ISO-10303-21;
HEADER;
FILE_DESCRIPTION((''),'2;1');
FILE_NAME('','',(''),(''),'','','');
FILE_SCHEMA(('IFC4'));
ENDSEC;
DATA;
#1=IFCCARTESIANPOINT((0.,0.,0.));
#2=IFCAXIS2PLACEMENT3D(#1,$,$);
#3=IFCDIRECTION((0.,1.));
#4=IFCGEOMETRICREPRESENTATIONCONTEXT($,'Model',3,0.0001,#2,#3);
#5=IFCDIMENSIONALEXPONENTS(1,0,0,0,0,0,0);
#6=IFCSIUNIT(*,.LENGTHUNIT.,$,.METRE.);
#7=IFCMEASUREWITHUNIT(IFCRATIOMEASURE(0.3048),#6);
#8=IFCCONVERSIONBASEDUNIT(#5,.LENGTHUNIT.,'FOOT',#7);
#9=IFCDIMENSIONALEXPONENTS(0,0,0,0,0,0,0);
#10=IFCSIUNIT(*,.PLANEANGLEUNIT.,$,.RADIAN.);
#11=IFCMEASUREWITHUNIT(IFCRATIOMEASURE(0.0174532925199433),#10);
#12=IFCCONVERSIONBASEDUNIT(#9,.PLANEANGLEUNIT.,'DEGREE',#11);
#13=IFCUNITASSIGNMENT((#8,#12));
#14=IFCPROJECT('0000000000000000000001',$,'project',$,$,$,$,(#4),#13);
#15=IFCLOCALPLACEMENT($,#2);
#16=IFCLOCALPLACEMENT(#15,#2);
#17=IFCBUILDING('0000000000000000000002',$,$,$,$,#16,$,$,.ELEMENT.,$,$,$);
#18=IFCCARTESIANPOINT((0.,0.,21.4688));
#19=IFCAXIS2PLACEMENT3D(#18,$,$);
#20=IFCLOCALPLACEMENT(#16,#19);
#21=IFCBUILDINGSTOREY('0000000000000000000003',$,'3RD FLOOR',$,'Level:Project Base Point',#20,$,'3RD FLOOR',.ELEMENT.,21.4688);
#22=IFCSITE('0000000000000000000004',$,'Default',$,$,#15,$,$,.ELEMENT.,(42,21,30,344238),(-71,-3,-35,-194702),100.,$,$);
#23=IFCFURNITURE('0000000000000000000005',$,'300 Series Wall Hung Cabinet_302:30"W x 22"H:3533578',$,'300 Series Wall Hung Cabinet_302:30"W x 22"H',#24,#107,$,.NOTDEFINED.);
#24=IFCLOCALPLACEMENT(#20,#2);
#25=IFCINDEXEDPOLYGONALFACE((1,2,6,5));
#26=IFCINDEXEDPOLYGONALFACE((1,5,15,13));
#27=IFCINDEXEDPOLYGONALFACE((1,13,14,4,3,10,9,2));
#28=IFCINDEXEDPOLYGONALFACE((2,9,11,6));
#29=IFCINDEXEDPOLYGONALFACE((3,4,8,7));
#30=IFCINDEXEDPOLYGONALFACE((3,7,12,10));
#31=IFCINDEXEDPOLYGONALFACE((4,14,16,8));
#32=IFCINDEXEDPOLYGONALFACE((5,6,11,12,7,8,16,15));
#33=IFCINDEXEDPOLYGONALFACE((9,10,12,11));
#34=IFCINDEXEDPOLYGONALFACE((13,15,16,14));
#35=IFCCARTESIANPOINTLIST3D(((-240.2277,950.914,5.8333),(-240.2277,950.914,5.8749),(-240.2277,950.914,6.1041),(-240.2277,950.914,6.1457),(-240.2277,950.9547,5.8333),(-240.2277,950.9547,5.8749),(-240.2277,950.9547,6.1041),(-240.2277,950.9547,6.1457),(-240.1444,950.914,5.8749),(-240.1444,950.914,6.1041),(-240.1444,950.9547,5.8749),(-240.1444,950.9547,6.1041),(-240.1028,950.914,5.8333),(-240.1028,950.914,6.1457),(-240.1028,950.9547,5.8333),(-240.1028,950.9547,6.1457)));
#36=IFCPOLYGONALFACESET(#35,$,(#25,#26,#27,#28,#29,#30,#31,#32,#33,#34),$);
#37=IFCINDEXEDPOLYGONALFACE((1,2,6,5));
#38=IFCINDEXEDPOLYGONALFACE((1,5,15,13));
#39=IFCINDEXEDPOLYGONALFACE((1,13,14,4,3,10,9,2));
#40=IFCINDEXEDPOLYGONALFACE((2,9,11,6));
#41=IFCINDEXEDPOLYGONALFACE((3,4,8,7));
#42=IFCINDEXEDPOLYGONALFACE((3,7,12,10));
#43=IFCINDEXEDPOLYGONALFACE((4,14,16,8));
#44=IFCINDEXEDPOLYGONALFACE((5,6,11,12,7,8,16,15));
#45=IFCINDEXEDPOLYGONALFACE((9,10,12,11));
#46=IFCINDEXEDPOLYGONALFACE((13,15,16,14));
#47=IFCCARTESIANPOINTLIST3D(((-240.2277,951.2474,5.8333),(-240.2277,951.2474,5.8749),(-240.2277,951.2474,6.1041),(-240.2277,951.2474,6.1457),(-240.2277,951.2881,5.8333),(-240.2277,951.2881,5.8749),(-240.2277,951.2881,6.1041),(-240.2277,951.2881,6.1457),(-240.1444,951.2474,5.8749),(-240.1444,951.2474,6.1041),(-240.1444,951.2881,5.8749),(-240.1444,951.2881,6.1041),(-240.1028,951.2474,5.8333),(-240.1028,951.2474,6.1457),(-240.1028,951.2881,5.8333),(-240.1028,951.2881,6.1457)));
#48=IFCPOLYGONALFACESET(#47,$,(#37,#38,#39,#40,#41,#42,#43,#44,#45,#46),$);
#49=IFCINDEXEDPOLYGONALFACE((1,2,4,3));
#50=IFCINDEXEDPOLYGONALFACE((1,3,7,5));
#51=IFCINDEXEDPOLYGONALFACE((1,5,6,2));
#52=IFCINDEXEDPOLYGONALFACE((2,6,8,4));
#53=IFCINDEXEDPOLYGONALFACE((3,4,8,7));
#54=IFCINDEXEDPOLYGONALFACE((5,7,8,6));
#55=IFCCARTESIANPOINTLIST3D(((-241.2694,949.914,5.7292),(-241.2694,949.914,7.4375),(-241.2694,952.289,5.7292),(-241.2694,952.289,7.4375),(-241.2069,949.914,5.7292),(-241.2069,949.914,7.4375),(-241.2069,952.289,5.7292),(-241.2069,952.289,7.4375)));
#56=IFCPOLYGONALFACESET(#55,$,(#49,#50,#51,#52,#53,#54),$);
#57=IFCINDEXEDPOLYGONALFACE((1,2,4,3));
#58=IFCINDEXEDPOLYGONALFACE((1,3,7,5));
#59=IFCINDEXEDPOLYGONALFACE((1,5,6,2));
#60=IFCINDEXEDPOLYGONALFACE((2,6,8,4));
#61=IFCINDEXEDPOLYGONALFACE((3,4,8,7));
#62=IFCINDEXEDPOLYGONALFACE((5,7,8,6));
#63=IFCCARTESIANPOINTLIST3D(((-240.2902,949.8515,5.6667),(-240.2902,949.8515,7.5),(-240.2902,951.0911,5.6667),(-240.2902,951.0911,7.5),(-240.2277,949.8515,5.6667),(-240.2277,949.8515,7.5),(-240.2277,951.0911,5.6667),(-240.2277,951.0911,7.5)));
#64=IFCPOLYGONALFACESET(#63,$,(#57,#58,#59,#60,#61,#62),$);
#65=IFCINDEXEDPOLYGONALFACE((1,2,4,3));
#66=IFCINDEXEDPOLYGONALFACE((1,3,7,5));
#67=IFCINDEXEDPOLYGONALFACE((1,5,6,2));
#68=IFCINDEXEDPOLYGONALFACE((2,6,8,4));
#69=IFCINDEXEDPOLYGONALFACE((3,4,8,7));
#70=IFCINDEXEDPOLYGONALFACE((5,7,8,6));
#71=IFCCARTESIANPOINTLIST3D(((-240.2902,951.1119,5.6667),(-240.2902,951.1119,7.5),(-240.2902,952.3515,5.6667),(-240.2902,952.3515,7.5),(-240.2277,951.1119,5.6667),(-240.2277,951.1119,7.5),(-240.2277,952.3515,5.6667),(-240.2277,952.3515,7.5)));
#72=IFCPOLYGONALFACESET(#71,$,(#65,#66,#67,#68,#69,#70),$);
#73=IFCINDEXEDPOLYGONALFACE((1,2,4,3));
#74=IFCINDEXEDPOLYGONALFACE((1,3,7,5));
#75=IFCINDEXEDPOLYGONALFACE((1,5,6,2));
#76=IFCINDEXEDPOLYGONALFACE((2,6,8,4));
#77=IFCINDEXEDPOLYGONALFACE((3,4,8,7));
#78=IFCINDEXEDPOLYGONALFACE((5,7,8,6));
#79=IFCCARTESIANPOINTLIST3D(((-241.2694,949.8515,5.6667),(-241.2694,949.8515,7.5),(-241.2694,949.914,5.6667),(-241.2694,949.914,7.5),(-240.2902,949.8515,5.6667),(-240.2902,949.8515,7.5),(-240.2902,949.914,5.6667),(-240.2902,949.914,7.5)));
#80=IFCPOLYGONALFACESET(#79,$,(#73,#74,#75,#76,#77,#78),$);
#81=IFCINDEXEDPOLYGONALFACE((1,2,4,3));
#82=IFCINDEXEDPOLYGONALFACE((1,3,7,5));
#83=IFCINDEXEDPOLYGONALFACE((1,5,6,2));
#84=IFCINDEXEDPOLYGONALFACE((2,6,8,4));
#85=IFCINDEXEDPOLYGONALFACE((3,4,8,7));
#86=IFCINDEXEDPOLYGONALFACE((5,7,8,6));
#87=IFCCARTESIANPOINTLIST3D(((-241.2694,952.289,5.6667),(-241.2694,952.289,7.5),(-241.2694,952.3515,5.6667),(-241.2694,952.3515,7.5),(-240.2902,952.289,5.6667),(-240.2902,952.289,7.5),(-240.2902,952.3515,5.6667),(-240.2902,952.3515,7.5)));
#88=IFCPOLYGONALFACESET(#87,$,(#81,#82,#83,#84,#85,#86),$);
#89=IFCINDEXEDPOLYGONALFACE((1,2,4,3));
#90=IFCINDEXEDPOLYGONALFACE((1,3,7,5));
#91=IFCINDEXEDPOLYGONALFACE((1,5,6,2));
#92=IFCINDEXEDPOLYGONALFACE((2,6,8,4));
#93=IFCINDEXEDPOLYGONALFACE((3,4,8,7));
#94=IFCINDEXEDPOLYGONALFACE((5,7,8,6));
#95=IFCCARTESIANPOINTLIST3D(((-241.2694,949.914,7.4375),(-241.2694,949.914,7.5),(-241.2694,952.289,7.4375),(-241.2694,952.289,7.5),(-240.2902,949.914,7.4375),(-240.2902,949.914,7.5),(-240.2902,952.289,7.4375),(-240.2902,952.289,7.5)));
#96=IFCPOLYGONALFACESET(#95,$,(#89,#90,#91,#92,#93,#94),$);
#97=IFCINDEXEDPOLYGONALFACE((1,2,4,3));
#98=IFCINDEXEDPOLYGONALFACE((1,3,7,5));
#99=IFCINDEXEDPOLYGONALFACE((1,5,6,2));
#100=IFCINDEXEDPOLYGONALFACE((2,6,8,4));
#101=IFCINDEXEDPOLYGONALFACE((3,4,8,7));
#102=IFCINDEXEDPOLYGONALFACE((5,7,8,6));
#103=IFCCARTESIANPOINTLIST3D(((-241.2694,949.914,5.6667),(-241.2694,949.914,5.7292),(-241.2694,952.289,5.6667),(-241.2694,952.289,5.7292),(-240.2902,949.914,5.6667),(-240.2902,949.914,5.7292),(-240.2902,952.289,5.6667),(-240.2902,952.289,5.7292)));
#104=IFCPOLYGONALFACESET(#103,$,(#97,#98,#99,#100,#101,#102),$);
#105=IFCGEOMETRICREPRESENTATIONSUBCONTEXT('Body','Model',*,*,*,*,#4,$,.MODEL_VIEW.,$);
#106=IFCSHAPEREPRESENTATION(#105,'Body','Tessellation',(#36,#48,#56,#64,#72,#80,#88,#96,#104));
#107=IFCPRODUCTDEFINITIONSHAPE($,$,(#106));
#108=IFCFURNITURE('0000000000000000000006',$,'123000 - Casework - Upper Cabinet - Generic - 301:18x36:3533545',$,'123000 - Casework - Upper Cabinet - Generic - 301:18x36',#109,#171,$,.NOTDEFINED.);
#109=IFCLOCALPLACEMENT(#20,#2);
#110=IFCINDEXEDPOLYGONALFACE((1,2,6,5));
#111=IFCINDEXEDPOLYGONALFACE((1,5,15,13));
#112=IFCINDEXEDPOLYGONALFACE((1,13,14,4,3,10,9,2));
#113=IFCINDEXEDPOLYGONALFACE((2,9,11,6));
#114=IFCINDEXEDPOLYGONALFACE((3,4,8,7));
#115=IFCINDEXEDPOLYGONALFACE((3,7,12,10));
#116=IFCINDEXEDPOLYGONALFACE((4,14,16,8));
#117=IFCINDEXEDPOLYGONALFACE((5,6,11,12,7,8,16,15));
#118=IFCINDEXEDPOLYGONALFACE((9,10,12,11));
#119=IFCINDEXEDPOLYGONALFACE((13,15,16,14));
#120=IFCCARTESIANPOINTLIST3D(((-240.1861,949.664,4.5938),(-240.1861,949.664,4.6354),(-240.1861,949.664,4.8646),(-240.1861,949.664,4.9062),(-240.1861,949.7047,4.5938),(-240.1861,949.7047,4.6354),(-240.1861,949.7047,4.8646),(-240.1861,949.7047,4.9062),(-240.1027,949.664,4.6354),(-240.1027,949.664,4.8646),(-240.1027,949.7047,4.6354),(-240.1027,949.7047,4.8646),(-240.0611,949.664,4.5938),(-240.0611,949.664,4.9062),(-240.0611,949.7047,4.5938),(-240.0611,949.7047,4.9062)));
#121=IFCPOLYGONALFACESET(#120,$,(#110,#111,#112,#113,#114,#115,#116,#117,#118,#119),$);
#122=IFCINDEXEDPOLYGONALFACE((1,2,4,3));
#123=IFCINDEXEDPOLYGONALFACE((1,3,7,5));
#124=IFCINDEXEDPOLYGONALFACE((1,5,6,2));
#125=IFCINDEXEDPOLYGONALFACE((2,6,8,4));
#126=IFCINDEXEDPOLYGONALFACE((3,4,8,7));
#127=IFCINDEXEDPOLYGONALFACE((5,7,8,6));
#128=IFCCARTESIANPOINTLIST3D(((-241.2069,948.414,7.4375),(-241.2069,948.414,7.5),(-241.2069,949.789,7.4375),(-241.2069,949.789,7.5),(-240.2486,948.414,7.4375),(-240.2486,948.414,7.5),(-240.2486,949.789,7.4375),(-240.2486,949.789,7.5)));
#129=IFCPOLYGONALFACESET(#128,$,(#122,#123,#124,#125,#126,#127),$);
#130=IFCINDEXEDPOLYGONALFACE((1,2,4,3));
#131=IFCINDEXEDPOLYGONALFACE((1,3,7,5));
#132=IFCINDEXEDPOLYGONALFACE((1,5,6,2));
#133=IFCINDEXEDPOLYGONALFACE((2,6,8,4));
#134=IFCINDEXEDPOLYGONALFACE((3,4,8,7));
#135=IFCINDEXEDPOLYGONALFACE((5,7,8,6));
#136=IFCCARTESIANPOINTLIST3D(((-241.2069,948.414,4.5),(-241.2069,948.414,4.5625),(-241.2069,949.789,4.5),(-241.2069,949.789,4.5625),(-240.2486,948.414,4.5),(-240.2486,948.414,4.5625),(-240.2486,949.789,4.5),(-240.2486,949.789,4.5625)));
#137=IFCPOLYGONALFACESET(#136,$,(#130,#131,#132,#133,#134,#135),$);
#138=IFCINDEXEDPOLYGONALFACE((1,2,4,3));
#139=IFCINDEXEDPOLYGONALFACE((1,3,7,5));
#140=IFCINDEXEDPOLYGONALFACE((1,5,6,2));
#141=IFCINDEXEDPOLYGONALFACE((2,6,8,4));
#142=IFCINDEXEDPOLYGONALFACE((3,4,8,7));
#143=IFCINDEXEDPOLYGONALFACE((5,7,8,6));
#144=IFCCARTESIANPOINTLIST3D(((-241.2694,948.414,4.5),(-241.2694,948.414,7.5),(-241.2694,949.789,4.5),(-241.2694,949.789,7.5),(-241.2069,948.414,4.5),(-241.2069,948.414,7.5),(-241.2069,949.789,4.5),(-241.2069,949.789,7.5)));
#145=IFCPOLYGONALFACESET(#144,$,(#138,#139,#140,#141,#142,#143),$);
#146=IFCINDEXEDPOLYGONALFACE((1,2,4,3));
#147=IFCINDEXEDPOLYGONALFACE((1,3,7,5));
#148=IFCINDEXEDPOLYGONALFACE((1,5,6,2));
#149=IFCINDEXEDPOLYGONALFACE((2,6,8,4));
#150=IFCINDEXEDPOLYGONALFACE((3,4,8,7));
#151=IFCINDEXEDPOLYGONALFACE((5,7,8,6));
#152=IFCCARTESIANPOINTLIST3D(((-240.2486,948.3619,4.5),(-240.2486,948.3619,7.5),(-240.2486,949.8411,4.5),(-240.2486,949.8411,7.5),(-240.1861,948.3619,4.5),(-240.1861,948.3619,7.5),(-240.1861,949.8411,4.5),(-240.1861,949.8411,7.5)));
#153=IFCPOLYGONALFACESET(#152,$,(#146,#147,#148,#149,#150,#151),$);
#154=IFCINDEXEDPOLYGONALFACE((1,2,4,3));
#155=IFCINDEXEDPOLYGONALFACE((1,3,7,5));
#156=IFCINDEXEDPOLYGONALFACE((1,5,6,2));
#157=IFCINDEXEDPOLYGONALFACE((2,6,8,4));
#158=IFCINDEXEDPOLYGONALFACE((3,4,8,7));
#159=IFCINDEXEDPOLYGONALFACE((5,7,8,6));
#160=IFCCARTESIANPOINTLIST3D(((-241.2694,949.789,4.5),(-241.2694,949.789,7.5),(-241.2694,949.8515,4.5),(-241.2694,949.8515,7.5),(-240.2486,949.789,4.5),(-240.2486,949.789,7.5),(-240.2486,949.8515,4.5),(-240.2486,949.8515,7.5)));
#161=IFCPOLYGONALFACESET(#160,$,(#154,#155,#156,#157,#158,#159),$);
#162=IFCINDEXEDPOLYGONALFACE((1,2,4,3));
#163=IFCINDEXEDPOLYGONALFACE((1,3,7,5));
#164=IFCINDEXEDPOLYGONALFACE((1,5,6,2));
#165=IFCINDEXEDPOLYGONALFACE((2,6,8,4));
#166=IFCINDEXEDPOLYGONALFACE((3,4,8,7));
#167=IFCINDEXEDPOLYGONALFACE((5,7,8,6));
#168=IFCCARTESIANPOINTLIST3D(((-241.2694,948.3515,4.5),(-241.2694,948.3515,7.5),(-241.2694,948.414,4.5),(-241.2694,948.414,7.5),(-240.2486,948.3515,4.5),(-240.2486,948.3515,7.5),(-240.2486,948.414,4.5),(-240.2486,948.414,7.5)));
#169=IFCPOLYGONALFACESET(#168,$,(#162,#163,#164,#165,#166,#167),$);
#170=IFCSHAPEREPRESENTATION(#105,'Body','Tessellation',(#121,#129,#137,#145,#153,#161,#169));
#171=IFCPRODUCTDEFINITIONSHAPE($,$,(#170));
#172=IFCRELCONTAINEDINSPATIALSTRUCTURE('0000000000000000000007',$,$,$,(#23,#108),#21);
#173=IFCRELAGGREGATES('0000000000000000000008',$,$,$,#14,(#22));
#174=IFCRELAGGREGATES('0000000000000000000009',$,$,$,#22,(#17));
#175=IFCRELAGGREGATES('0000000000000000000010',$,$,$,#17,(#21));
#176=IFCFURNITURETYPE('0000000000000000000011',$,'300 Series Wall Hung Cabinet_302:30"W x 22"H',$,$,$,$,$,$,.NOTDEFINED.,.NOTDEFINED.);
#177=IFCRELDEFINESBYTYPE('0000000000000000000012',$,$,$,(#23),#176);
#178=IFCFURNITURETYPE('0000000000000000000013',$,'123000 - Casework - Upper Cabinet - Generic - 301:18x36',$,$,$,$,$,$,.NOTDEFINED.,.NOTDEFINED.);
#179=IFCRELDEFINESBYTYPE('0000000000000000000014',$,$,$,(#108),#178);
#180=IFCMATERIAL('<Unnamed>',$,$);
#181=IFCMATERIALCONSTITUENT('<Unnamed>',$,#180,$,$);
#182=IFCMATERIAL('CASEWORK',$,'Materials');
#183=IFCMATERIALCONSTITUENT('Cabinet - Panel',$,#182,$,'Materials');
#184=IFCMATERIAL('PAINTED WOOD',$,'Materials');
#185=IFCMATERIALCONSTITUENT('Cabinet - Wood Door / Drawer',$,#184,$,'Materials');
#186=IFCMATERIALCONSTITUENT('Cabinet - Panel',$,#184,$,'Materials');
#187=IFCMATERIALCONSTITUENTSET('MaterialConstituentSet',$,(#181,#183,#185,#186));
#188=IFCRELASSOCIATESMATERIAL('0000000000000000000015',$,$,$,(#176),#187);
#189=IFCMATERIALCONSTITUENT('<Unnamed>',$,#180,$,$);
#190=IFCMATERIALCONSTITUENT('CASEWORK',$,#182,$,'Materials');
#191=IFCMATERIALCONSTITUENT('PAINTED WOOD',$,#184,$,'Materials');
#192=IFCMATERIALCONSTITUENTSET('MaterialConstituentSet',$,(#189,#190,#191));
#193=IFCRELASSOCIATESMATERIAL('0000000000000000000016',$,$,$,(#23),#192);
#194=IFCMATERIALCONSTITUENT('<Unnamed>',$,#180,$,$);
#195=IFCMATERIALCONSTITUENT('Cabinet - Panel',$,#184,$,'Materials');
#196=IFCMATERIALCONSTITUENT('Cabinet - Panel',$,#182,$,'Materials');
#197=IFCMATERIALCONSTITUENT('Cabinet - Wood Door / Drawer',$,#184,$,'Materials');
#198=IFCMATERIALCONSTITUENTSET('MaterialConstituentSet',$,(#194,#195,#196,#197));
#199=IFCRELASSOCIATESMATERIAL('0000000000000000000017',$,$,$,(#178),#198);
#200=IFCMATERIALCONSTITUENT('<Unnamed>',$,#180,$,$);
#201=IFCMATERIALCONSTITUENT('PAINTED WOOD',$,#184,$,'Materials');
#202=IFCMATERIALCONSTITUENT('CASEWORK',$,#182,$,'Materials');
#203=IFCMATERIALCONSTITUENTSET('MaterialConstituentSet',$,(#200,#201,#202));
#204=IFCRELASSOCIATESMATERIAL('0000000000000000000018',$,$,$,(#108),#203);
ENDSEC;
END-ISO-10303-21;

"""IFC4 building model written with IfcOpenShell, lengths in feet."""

from ifc_helpers import new_model, entity, si_unit, converted_unit, direction, frame, frame_2d, origin, origin_2d_with_axis, place, context, subcontext, project, spatial, polyline, rectangle, outline, extrude, source, transform, mapped, material, constituent, constituent_set, type_object, type_shapes, element, save


model = new_model("IFC4")

# Units and contexts
model_context = context("Model", 3, precision=0.0001, world=origin(), true_north=direction((0.0, 1.0)))
body_context = subcontext(model_context, "Body", "Model", "MODEL_VIEW")
ifc_project = project(units=[converted_unit("LENGTHUNIT", "FOOT", entity("IfcRatioMeasure", 0.3048), si_unit("LENGTHUNIT", "METRE"), dimensions=[1, 0, 0, 0, 0, 0, 0]), converted_unit("PLANEANGLEUNIT", "DEGREE", entity("IfcRatioMeasure", 0.0174532925199433), si_unit("PLANEANGLEUNIT", "RADIAN"), dimensions=[0, 0, 0, 0, 0, 0, 0])], contexts=[model_context])

# Site, building, storey
site_placement = place(None, origin())
site = spatial("IfcSite", under=ifc_project, at=site_placement, Name="Default", CompositionType="ELEMENT", RefLatitude=(42, 21, 30, 344238), RefLongitude=(-71, -3, -35, -194702), RefElevation=100.0)
building_placement = place(site_placement, origin())
building = spatial("IfcBuilding", under=site, at=building_placement, CompositionType="ELEMENT")
storey_placement = place(building_placement, frame((0.0, 0.0, 21.4688)))
storey = spatial("IfcBuildingStorey", under=building, at=storey_placement, Name="3RD FLOOR", ObjectType="Level:Project Base Point", LongName="3RD FLOOR", CompositionType="ELEMENT", Elevation=21.4688)

# Furniture
ifc_material_1 = material(Name="PAINTED WOOD", Category="Materials")
ifc_material_2 = material(Name="CASEWORK", Category="Materials")
ifc_material_3 = material(Name="<Unnamed>")
ifc_constituent_1 = constituent(ifc_material_3, Name="<Unnamed>")
ifc_constituent_2 = constituent(ifc_material_2, Name="CASEWORK", Category="Materials")
ifc_constituent_3 = constituent(ifc_material_1, Name="PAINTED WOOD", Category="Materials")
ifc_constituent_set_1 = constituent_set(constituents=[ifc_constituent_1, ifc_constituent_2, ifc_constituent_3], Name="MaterialConstituentSet")
ifc_constituent_4 = constituent(ifc_material_3, Name="<Unnamed>")
ifc_constituent_5 = constituent(ifc_material_2, Name="Cabinet - Panel", Category="Materials")
ifc_constituent_6 = constituent(ifc_material_1, Name="Cabinet - Wood Door / Drawer", Category="Materials")
ifc_constituent_7 = constituent(ifc_material_1, Name="Cabinet - Panel", Category="Materials")
ifc_constituent_set_2 = constituent_set(constituents=[ifc_constituent_4, ifc_constituent_5, ifc_constituent_6, ifc_constituent_7], Name="MaterialConstituentSet")
furniture_type_1 = type_object("IfcFurnitureType", Name="300 Series Wall Hung Cabinet_302:30\"W x 22\"H", AssemblyPlace="NOTDEFINED", PredefinedType="NOTDEFINED", material=ifc_constituent_set_2)
shared_shape_1 = source(origin(), body_context, "Body", "SweptSolid", [
    extrude(outline(polyline([(0.1146, -0.0521), (0.1562, -0.0521), (0.1562, 0.0729), (-0.1562, 0.0729), (-0.1562, -0.0521), (-0.1146, -0.0521), (-0.1146, 0.0313), (0.1146, 0.0313), (0.1146, -0.0521)])), frame((1.0625, 0.0729, 0.3229), z_axis=(1.0, 0.0, 0.0), x_axis=(0.0, 0.0, 1.0)), (0.0, 0.0, 1.0), 0.0407),
    extrude(outline(polyline([(0.1146, -0.0521), (0.1562, -0.0521), (0.1562, 0.0729), (-0.1562, 0.0729), (-0.1562, -0.0521), (-0.1146, -0.0521), (-0.1146, 0.0313), (0.1146, 0.0313), (0.1146, -0.0521)])), frame((1.3958, 0.0729, 0.3229), z_axis=(1.0, 0.0, 0.0), x_axis=(0.0, 0.0, 1.0)), (0.0, 0.0, 1.0), 0.0407),
    extrude(rectangle(XDim=2.375, YDim=0.0625, at=origin_2d_with_axis()), frame((1.25, 1.1354, 0.0625), z_axis=(0.0, 0.0, 1.0), x_axis=(-1.0, 0.0, 0.0)), (0.0, 0.0, 1.0), 1.7083),
    extrude(rectangle(XDim=1.2396, YDim=0.0625, at=origin_2d_with_axis()), frame((0.6198, 0.1562, 0.0), z_axis=(0.0, 0.0, 1.0), x_axis=(-1.0, 0.0, 0.0)), (0.0, 0.0, 1.0), 1.8333),
    extrude(rectangle(XDim=1.2396, YDim=0.0625, at=frame_2d((0.0, 0.0), x_axis=(1.0, 0.0))), frame((1.8802, 0.1562, 0.0), z_axis=(0.0, 0.0, 1.0), x_axis=(-1.0, 0.0, 0.0)), (0.0, 0.0, 1.0), 1.8333),
    extrude(rectangle(XDim=0.9792, YDim=0.0625, at=frame_2d((0.0, 0.0), x_axis=(1.0, 0.0))), frame((0.0313, 0.677, 0.0), z_axis=(0.0, 0.0, 1.0), x_axis=(0.0, -1.0, 0.0)), (0.0, 0.0, 1.0), 1.8333),
    extrude(rectangle(XDim=0.9792, YDim=0.0625, at=frame_2d((0.0, 0.0), x_axis=(1.0, 0.0))), frame((2.4688, 0.677, 0.0), z_axis=(0.0, 0.0, 1.0), x_axis=(0.0, -1.0, 0.0)), (0.0, 0.0, 1.0), 1.8333),
    extrude(rectangle(XDim=0.9792, YDim=2.375, at=frame_2d((0.0, 0.0), x_axis=(1.0, 0.0))), frame((1.25, 0.677, 1.7708), z_axis=(0.0, 0.0, 1.0), x_axis=(0.0, 1.0, 0.0)), (0.0, 0.0, 1.0), 0.0625),
    extrude(rectangle(XDim=0.9792, YDim=2.375, at=frame_2d((0.0, 0.0), x_axis=(1.0, 0.0))), frame((1.25, 0.677, 0.0), z_axis=(0.0, 0.0, 1.0), x_axis=(0.0, 1.0, 0.0)), (0.0, 0.0, 1.0), 0.0625),
])
type_shapes(furniture_type_1, [shared_shape_1])
furniture_1_placement = place(storey_placement, frame((-240.1028, 949.8515, 5.6667), z_axis=(0.0, 0.0, 1.0), x_axis=(0.0, 1.0, 0.0)))
element("IfcFurniture", 1, at=furniture_1_placement, inside=storey, type_object=furniture_type_1, material=ifc_constituent_set_1, Name="300 Series Wall Hung Cabinet_302:30\"W x 22\"H:3533578", ObjectType="300 Series Wall Hung Cabinet_302:30\"W x 22\"H", PredefinedType="NOTDEFINED", context=body_context, shape_type="MappedRepresentation", body=[
    mapped(shared_shape_1, transform((0.0, 0.0, 0.0), scale=1.0)),
])
ifc_constituent_8 = constituent(ifc_material_3, Name="<Unnamed>")
ifc_constituent_9 = constituent(ifc_material_1, Name="PAINTED WOOD", Category="Materials")
ifc_constituent_10 = constituent(ifc_material_2, Name="CASEWORK", Category="Materials")
ifc_constituent_set_3 = constituent_set(constituents=[ifc_constituent_8, ifc_constituent_9, ifc_constituent_10], Name="MaterialConstituentSet")
ifc_constituent_11 = constituent(ifc_material_3, Name="<Unnamed>")
ifc_constituent_12 = constituent(ifc_material_1, Name="Cabinet - Panel", Category="Materials")
ifc_constituent_13 = constituent(ifc_material_2, Name="Cabinet - Panel", Category="Materials")
ifc_constituent_14 = constituent(ifc_material_1, Name="Cabinet - Wood Door / Drawer", Category="Materials")
ifc_constituent_set_4 = constituent_set(constituents=[ifc_constituent_11, ifc_constituent_12, ifc_constituent_13, ifc_constituent_14], Name="MaterialConstituentSet")
furniture_type_2 = type_object("IfcFurnitureType", Name="123000 - Casework - Upper Cabinet - Generic - 301:18x36", AssemblyPlace="NOTDEFINED", PredefinedType="NOTDEFINED", material=ifc_constituent_set_4)
shared_shape_2 = source(origin(), body_context, "Body", "SweptSolid", [
    extrude(outline(polyline([(-0.0521, -0.1146), (-0.0521, -0.1562), (0.0729, -0.1562), (0.0729, 0.1562), (-0.0521, 0.1562), (-0.0521, 0.1146), (0.0313, 0.1146), (0.0313, -0.1146), (-0.0521, -0.1146)])), frame((0.1468, 1.1354, 0.25), z_axis=(-1.0, 0.0, 0.0), x_axis=(0.0, 1.0, 0.0)), (0.0, 0.0, -1.0), 0.0407),
    extrude(rectangle(XDim=0.9583, YDim=1.375, at=frame_2d((0.0, 0.0), x_axis=(1.0, 0.0))), frame((0.75, 0.5417, 2.9375), z_axis=(0.0, 0.0, 1.0), x_axis=(0.0, 1.0, 0.0)), (0.0, 0.0, 1.0), 0.0625),
    extrude(rectangle(XDim=0.9583, YDim=1.375, at=frame_2d((0.0, 0.0), x_axis=(1.0, 0.0))), frame((0.75, 0.5417, 0.0), z_axis=(0.0, 0.0, 1.0), x_axis=(0.0, 1.0, 0.0)), (0.0, 0.0, 1.0), 0.0625),
    extrude(rectangle(XDim=1.375, YDim=0.0625, at=origin_2d_with_axis()), frame((0.75, 0.0313, 0.0), z_axis=(0.0, 0.0, 1.0), x_axis=(-1.0, 0.0, 0.0)), (0.0, 0.0, 1.0), 3.0),
    extrude(rectangle(XDim=1.4792, YDim=0.0625, at=origin_2d_with_axis()), frame((0.75, 1.0521, 0.0)), (0.0, 0.0, 1.0), 3.0),
    extrude(rectangle(XDim=1.0208, YDim=0.0625, at=origin_2d_with_axis()), frame((0.0312, 0.5104, 0.0), z_axis=(0.0, 0.0, 1.0), x_axis=(0.0, 1.0, 0.0)), (0.0, 0.0, 1.0), 3.0),
    extrude(rectangle(XDim=1.0208, YDim=0.0625, at=origin_2d_with_axis()), frame((1.4688, 0.5104, 0.0), z_axis=(0.0, 0.0, 1.0), x_axis=(0.0, 1.0, 0.0)), (0.0, 0.0, 1.0), 3.0),
])
type_shapes(furniture_type_2, [shared_shape_2])
furniture_2_placement = place(storey_placement, frame((-241.2694, 949.8515, 4.5), z_axis=(0.0, 0.0, 1.0), x_axis=(0.0, -1.0, 0.0)))
element("IfcFurniture", 2, at=furniture_2_placement, inside=storey, type_object=furniture_type_2, material=ifc_constituent_set_3, Name="123000 - Casework - Upper Cabinet - Generic - 301:18x36:3533545", ObjectType="123000 - Casework - Upper Cabinet - Generic - 301:18x36", PredefinedType="NOTDEFINED", context=body_context, shape_type="MappedRepresentation", body=[
    mapped(shared_shape_2, transform((0.0, 0.0, 0.0), scale=1.0)),
])

save(model, "model.ifc")
